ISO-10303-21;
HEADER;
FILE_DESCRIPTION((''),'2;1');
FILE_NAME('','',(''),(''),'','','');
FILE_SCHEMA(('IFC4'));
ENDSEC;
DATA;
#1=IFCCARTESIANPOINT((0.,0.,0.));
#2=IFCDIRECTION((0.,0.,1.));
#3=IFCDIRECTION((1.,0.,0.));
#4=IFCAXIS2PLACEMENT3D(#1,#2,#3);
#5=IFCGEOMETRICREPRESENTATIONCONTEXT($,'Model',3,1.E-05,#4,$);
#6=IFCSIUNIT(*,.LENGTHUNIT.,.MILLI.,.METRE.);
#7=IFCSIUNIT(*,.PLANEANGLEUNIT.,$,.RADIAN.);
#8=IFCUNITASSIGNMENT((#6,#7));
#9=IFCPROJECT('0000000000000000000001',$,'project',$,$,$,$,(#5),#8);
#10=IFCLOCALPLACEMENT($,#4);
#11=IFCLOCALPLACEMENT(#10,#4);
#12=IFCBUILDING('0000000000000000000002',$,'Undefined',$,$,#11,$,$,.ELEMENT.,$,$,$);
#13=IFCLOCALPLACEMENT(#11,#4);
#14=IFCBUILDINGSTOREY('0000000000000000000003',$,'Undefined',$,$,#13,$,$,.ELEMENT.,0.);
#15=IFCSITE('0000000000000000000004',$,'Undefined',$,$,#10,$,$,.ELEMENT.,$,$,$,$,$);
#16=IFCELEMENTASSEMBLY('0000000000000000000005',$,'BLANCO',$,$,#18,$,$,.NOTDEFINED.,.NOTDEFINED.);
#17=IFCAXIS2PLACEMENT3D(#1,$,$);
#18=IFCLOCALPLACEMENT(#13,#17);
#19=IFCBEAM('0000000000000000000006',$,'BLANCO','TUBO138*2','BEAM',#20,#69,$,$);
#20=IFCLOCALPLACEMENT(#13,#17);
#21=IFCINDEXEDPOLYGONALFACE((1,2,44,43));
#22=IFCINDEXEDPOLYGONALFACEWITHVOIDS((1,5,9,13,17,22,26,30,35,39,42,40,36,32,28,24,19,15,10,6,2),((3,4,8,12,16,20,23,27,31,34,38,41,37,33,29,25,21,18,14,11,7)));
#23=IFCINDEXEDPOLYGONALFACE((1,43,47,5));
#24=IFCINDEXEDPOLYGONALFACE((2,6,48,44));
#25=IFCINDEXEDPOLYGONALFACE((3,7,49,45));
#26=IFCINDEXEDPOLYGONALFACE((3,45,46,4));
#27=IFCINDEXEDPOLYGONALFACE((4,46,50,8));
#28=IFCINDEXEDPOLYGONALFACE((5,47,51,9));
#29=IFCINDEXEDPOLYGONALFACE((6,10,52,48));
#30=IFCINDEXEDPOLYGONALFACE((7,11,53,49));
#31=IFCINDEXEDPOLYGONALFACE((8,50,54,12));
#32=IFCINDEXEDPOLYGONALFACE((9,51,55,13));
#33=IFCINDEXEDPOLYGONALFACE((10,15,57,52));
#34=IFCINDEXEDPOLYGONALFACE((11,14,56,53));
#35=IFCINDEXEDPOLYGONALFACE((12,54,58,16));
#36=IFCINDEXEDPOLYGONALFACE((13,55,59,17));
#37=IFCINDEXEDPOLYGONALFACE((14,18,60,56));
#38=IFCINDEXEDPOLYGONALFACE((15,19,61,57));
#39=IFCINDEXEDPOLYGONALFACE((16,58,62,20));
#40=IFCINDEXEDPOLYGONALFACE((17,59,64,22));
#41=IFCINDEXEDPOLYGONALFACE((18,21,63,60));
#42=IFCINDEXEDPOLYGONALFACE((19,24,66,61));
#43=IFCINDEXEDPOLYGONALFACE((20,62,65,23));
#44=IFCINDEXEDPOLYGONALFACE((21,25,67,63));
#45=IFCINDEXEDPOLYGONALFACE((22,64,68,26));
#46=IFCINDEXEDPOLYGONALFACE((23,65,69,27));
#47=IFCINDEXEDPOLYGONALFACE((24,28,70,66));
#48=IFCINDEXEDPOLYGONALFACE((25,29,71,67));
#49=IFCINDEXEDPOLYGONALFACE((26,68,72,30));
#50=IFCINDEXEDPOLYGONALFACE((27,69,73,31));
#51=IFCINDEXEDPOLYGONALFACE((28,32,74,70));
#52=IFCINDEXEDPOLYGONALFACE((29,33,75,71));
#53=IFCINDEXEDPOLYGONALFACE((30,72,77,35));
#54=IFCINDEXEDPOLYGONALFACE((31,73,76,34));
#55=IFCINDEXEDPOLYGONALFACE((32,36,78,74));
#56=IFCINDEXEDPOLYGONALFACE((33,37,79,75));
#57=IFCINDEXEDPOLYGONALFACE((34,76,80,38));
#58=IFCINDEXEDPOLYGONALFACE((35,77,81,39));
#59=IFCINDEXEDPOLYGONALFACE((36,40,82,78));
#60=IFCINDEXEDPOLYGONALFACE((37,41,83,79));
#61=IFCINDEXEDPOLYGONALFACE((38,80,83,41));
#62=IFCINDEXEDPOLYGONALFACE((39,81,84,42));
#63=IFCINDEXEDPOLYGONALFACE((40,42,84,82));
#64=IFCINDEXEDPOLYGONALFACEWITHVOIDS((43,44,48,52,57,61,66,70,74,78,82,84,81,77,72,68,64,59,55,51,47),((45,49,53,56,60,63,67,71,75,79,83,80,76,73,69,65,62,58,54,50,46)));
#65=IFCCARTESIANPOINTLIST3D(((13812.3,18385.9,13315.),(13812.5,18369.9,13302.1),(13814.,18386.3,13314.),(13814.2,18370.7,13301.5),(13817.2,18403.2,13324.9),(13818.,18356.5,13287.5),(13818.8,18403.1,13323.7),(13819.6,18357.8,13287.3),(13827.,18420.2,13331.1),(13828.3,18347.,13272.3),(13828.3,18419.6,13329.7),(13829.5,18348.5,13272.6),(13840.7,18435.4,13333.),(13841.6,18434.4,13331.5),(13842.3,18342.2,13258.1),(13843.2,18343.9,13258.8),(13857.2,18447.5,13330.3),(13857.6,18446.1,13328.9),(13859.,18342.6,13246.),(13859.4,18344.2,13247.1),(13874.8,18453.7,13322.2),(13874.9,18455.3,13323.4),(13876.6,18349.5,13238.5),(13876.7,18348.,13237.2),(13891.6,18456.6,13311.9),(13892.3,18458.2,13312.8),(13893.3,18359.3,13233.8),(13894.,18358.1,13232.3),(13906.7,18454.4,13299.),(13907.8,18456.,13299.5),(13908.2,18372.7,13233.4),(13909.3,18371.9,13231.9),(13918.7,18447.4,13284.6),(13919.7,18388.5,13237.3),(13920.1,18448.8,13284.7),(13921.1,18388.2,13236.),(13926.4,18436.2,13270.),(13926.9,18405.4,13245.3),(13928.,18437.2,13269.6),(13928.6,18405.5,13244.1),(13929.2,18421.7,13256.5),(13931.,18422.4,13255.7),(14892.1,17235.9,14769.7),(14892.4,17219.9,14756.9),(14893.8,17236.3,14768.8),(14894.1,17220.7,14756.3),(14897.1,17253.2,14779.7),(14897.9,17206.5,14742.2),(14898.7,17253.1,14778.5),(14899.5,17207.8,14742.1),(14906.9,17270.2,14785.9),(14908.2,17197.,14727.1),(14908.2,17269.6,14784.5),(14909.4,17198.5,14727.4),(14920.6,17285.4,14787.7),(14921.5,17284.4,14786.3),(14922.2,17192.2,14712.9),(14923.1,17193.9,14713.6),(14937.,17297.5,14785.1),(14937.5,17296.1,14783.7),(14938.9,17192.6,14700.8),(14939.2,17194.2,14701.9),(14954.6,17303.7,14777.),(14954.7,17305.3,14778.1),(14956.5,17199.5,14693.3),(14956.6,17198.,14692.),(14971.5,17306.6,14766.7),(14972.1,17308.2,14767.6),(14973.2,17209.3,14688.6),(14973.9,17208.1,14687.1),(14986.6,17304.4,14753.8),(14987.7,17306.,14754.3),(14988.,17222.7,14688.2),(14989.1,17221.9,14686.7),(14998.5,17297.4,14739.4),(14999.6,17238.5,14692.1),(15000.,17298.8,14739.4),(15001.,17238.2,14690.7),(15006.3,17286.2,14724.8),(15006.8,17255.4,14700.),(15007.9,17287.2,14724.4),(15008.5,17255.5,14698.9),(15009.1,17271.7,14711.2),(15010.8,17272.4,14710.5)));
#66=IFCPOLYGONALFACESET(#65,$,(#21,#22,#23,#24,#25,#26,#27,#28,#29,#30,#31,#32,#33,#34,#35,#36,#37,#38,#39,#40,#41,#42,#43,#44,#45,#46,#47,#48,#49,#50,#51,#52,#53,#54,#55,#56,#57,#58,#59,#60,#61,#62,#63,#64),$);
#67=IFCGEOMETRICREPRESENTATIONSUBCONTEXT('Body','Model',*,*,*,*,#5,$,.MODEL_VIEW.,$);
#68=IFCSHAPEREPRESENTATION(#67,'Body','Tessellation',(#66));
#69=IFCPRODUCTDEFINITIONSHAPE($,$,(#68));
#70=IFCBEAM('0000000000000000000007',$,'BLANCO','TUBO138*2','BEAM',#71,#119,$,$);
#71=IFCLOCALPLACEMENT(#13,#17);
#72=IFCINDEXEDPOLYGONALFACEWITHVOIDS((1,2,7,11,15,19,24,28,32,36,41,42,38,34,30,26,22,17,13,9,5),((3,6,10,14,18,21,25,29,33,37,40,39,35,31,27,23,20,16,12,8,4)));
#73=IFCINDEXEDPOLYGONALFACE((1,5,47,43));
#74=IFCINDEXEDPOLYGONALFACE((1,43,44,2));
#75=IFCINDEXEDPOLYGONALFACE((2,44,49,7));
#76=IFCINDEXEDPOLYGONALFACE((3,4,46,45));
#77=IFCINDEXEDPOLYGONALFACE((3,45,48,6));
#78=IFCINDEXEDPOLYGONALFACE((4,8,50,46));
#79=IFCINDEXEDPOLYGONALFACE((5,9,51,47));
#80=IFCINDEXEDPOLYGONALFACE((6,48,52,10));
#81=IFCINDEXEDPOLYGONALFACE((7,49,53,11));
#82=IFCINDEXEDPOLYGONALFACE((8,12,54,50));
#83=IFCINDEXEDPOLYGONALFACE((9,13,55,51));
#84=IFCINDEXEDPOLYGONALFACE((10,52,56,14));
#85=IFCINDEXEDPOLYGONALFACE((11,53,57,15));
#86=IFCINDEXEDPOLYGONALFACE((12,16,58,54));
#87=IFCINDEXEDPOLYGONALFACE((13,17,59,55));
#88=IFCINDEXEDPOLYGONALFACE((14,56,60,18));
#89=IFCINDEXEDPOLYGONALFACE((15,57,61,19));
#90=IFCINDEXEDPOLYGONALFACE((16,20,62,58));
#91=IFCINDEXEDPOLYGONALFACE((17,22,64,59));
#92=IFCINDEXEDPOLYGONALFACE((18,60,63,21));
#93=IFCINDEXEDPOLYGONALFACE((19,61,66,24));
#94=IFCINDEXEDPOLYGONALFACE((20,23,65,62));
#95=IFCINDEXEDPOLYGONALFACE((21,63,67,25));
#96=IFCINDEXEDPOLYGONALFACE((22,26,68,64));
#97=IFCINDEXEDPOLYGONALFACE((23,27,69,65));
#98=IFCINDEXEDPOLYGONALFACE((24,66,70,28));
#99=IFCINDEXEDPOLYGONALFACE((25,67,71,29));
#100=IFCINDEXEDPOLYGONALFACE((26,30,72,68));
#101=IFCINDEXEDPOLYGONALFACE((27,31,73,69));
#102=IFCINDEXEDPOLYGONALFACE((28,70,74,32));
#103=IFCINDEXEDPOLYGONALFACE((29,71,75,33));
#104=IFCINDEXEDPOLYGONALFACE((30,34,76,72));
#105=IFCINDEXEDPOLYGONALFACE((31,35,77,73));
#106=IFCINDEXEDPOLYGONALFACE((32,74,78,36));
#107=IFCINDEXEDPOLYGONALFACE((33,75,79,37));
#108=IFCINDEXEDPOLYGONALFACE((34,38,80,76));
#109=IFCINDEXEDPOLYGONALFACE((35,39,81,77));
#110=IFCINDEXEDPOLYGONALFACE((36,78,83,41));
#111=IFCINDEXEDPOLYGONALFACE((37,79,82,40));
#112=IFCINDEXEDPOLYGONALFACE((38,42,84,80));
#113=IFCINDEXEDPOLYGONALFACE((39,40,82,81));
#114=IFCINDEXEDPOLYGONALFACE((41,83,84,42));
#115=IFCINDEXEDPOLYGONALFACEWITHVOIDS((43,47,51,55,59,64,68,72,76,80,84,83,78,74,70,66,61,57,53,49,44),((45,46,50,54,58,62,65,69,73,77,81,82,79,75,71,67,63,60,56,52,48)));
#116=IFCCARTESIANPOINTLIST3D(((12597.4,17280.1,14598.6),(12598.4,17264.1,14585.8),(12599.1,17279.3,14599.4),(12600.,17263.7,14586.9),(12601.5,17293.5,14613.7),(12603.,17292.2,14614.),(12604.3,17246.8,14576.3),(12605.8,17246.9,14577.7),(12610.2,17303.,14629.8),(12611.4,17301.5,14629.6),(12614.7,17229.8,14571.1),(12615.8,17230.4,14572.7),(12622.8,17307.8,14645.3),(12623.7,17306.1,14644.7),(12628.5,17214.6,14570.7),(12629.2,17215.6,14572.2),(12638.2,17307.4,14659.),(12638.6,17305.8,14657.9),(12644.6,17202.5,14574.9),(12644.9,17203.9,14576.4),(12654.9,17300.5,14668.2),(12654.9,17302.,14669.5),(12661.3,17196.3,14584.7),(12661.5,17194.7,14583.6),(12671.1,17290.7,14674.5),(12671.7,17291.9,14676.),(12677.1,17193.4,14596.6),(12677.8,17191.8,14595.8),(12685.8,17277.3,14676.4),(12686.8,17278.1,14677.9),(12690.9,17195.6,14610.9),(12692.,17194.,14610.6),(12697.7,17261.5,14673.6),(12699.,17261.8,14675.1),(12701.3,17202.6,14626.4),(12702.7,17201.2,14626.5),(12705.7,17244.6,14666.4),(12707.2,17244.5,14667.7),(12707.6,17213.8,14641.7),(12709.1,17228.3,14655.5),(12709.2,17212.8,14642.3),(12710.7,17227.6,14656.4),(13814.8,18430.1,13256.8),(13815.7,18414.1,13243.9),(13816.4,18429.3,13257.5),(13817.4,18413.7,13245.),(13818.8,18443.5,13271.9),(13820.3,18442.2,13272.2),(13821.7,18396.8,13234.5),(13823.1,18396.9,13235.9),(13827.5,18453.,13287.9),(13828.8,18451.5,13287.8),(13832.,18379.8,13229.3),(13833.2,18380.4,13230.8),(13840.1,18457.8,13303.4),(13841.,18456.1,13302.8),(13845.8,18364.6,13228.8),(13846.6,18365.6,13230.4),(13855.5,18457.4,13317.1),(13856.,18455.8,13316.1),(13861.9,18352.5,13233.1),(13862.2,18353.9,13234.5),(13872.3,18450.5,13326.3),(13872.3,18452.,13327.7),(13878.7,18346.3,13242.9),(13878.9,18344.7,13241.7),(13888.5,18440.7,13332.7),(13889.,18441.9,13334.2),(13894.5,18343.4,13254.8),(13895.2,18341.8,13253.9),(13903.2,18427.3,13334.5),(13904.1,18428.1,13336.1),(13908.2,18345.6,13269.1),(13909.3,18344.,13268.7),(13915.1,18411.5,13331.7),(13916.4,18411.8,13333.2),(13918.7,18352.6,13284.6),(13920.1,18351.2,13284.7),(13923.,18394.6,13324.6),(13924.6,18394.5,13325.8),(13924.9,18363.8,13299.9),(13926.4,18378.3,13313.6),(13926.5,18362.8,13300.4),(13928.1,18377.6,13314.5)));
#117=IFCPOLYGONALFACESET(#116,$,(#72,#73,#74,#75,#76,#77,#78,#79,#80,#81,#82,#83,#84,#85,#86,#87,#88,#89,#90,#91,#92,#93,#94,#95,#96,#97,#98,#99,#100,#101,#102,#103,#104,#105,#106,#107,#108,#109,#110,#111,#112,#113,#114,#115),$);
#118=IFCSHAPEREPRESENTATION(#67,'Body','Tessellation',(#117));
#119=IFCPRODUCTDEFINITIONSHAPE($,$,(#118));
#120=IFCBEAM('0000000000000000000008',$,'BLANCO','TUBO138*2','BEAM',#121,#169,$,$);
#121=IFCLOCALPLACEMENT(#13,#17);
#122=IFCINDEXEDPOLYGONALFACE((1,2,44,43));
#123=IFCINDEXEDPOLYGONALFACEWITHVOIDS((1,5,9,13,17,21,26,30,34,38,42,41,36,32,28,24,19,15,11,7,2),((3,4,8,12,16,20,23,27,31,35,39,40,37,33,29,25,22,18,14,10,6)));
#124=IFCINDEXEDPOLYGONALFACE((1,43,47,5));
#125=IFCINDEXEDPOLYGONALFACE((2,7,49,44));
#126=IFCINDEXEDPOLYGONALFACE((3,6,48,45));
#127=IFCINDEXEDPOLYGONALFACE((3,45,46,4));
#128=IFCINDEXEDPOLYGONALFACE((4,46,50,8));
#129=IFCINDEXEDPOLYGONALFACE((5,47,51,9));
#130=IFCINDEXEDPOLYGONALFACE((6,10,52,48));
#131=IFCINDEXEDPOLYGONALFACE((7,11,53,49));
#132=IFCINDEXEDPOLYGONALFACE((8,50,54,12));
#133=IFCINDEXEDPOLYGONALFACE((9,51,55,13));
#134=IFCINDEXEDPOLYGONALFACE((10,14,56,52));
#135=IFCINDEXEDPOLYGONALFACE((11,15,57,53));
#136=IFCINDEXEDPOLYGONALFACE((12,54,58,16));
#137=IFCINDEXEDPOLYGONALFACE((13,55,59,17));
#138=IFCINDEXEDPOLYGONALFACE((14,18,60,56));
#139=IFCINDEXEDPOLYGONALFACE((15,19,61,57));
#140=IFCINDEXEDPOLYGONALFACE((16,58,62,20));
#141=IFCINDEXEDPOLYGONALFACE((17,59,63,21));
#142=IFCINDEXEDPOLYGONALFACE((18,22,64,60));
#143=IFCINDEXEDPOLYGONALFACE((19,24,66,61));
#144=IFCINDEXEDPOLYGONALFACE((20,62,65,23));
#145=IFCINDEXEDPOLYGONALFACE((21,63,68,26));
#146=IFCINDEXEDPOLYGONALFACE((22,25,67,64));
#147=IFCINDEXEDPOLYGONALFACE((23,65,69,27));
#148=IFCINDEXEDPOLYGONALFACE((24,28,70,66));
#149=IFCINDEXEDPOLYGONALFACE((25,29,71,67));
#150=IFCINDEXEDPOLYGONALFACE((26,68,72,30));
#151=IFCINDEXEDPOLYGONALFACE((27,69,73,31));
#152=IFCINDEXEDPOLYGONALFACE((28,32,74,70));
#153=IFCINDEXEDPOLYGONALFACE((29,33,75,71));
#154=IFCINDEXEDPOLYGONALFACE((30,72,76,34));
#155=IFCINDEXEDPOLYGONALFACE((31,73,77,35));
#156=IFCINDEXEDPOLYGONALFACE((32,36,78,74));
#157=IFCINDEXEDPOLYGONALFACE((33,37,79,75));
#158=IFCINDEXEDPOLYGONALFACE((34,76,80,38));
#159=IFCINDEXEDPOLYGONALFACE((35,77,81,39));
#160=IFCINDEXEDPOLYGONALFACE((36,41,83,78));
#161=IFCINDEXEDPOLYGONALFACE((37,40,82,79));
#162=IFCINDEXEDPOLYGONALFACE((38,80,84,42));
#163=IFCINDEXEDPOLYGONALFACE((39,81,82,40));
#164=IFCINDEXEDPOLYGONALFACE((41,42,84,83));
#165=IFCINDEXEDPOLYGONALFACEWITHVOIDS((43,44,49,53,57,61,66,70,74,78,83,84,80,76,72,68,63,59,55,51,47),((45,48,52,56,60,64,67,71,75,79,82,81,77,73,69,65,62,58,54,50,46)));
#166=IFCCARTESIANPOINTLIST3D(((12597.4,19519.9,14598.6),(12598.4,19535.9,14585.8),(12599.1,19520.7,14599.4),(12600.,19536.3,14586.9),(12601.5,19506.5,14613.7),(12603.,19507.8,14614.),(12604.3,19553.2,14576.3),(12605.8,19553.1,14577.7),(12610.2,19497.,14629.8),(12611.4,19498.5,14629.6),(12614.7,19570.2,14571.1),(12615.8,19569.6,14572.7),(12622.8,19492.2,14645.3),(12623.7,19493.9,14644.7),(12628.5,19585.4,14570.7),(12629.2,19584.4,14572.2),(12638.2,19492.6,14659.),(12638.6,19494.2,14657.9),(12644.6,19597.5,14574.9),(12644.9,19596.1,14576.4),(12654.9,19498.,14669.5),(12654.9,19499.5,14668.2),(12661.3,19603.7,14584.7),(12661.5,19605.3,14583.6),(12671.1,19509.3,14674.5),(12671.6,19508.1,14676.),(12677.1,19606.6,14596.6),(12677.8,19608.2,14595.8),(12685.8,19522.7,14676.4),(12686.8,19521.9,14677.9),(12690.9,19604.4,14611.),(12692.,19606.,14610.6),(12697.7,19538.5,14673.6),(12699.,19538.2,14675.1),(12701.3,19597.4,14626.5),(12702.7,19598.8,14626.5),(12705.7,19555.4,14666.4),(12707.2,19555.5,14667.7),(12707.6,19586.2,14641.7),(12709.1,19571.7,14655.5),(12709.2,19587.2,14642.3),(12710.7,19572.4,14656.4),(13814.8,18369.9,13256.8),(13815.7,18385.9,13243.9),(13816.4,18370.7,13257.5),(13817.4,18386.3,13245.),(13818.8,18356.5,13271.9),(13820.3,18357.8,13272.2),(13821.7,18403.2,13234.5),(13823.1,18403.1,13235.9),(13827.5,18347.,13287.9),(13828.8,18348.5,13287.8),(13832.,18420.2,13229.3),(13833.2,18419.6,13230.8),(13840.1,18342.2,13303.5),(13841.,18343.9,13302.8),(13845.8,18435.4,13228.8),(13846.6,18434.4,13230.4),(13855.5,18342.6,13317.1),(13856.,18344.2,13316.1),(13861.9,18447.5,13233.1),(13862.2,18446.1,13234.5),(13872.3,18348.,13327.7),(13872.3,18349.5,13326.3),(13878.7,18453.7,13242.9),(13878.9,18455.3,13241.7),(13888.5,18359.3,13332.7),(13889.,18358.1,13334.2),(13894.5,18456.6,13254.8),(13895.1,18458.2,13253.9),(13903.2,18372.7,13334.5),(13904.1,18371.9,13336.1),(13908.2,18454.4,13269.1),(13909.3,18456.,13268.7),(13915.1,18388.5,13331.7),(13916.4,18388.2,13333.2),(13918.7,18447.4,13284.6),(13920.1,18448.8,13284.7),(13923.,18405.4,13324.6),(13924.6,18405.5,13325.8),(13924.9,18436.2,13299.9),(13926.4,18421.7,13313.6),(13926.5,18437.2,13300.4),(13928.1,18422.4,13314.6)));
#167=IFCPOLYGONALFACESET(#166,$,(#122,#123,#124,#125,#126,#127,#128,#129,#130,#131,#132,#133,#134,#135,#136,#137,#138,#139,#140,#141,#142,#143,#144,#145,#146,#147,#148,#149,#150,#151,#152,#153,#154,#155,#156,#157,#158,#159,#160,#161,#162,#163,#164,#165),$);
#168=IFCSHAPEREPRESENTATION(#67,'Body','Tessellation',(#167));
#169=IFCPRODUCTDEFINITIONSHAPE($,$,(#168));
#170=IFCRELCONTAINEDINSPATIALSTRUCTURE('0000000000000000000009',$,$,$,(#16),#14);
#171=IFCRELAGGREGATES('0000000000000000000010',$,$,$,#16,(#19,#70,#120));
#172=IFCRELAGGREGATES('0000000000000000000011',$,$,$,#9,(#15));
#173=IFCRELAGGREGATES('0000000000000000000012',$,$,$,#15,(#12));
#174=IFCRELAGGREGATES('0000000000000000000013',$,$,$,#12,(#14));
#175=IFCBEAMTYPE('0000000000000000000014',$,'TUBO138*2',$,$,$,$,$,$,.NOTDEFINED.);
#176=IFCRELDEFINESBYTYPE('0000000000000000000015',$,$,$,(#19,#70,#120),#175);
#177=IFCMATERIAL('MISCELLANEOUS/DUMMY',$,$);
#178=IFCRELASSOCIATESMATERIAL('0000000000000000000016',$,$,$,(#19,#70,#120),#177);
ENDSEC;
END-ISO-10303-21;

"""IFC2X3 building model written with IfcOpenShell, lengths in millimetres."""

from ifc_helpers import new_model, si_unit, frame, origin_with_axes, origin_2d_with_axis, place, context, subcontext, project, spatial, hollow_circle, extrude, material, type_object, element, aggregate, save


model = new_model("IFC2X3")

# Units and contexts
model_context = context("Model", 3, precision=1e-05, world=origin_with_axes())
body_context = subcontext(model_context, "Body", "Model", "MODEL_VIEW")
ifc_project = project(units=[si_unit("LENGTHUNIT", "METRE", prefix="MILLI"), si_unit("PLANEANGLEUNIT", "RADIAN")], contexts=[model_context])

# Site, building, storey
site_placement = place(None, origin_with_axes())
site = spatial("IfcSite", under=ifc_project, at=site_placement, Name="Undefined", CompositionType="ELEMENT")
building_placement = place(site_placement, origin_with_axes())
building = spatial("IfcBuilding", under=site, at=building_placement, Name="Undefined", CompositionType="ELEMENT")
storey_placement = place(building_placement, origin_with_axes())
storey = spatial("IfcBuildingStorey", under=building, at=storey_placement, Name="Undefined", CompositionType="ELEMENT", Elevation=0.0)

# Element assembly, beams
assembly_placement = place(storey_placement, origin_with_axes())
assembly = element("IfcElementAssembly", 1, at=assembly_placement, inside=storey, Name="BLANCO", AssemblyPlace="NOTDEFINED", PredefinedType="NOTDEFINED")
ifc_material = material(Name="MISCELLANEOUS/DUMMY")
beam_type = type_object("IfcBeamType", Name="TUBO138*2", PredefinedType="NOTDEFINED")
beam_1_placement = place(assembly_placement, frame((13871.3, 18400.0, 13282.3), z_axis=(0.497966, -0.461316, -0.734314), x_axis=(0.503224, -0.535899, 0.677922)))
beam_1 = element("IfcBeam", 2, at=beam_1_placement, type_object=beam_type, material=ifc_material, Name="BLANCO", Description="TUBO138*2", ObjectType="BEAM", context=body_context, shape_type="SweptSolid", body=[
    extrude(hollow_circle(Radius=69.0, WallThickness=2.0, at=origin_2d_with_axis()), frame((2145.9, 0.0, 0.0), z_axis=(-1.0, 0.0, 0.0), x_axis=(0.0, -1.0, 0.0)), (0.0, 0.0, 1.0), 2145.9),
])
beam_2_placement = place(assembly_placement, frame((13871.3, 18400.0, 13282.3), z_axis=(-0.423552, -0.461316, -0.77961), x_axis=(-0.567282, -0.535899, 0.625303)))
beam_2 = element("IfcBeam", 3, at=beam_2_placement, type_object=beam_type, material=ifc_material, Name="BLANCO", Description="TUBO138*2", ObjectType="BEAM", context=body_context, shape_type="SweptSolid", body=[
    extrude(hollow_circle(Radius=69.0, WallThickness=2.0, at=origin_2d_with_axis()), frame((2145.9, 0.0, 0.0), z_axis=(-1.0, 0.0, 0.0), x_axis=(0.0, -1.0, 0.0)), (0.0, 0.0, 1.0), 2145.9),
])
beam_3_placement = place(assembly_placement, frame((12654.0, 19550.0, 14624.1), z_axis=(-0.423552, 0.461316, -0.77961), x_axis=(0.567282, -0.535899, -0.625303)))
beam_3 = element("IfcBeam", 4, at=beam_3_placement, type_object=beam_type, material=ifc_material, Name="BLANCO", Description="TUBO138*2", ObjectType="BEAM", context=body_context, shape_type="SweptSolid", body=[
    extrude(hollow_circle(Radius=69.0, WallThickness=2.0, at=origin_2d_with_axis()), frame((2145.9, 0.0, 0.0), z_axis=(-1.0, 0.0, 0.0), x_axis=(0.0, -1.0, 0.0)), (0.0, 0.0, 1.0), 2145.9),
])
aggregate(assembly, [beam_1, beam_2, beam_3])

save(model, "model.ifc")
